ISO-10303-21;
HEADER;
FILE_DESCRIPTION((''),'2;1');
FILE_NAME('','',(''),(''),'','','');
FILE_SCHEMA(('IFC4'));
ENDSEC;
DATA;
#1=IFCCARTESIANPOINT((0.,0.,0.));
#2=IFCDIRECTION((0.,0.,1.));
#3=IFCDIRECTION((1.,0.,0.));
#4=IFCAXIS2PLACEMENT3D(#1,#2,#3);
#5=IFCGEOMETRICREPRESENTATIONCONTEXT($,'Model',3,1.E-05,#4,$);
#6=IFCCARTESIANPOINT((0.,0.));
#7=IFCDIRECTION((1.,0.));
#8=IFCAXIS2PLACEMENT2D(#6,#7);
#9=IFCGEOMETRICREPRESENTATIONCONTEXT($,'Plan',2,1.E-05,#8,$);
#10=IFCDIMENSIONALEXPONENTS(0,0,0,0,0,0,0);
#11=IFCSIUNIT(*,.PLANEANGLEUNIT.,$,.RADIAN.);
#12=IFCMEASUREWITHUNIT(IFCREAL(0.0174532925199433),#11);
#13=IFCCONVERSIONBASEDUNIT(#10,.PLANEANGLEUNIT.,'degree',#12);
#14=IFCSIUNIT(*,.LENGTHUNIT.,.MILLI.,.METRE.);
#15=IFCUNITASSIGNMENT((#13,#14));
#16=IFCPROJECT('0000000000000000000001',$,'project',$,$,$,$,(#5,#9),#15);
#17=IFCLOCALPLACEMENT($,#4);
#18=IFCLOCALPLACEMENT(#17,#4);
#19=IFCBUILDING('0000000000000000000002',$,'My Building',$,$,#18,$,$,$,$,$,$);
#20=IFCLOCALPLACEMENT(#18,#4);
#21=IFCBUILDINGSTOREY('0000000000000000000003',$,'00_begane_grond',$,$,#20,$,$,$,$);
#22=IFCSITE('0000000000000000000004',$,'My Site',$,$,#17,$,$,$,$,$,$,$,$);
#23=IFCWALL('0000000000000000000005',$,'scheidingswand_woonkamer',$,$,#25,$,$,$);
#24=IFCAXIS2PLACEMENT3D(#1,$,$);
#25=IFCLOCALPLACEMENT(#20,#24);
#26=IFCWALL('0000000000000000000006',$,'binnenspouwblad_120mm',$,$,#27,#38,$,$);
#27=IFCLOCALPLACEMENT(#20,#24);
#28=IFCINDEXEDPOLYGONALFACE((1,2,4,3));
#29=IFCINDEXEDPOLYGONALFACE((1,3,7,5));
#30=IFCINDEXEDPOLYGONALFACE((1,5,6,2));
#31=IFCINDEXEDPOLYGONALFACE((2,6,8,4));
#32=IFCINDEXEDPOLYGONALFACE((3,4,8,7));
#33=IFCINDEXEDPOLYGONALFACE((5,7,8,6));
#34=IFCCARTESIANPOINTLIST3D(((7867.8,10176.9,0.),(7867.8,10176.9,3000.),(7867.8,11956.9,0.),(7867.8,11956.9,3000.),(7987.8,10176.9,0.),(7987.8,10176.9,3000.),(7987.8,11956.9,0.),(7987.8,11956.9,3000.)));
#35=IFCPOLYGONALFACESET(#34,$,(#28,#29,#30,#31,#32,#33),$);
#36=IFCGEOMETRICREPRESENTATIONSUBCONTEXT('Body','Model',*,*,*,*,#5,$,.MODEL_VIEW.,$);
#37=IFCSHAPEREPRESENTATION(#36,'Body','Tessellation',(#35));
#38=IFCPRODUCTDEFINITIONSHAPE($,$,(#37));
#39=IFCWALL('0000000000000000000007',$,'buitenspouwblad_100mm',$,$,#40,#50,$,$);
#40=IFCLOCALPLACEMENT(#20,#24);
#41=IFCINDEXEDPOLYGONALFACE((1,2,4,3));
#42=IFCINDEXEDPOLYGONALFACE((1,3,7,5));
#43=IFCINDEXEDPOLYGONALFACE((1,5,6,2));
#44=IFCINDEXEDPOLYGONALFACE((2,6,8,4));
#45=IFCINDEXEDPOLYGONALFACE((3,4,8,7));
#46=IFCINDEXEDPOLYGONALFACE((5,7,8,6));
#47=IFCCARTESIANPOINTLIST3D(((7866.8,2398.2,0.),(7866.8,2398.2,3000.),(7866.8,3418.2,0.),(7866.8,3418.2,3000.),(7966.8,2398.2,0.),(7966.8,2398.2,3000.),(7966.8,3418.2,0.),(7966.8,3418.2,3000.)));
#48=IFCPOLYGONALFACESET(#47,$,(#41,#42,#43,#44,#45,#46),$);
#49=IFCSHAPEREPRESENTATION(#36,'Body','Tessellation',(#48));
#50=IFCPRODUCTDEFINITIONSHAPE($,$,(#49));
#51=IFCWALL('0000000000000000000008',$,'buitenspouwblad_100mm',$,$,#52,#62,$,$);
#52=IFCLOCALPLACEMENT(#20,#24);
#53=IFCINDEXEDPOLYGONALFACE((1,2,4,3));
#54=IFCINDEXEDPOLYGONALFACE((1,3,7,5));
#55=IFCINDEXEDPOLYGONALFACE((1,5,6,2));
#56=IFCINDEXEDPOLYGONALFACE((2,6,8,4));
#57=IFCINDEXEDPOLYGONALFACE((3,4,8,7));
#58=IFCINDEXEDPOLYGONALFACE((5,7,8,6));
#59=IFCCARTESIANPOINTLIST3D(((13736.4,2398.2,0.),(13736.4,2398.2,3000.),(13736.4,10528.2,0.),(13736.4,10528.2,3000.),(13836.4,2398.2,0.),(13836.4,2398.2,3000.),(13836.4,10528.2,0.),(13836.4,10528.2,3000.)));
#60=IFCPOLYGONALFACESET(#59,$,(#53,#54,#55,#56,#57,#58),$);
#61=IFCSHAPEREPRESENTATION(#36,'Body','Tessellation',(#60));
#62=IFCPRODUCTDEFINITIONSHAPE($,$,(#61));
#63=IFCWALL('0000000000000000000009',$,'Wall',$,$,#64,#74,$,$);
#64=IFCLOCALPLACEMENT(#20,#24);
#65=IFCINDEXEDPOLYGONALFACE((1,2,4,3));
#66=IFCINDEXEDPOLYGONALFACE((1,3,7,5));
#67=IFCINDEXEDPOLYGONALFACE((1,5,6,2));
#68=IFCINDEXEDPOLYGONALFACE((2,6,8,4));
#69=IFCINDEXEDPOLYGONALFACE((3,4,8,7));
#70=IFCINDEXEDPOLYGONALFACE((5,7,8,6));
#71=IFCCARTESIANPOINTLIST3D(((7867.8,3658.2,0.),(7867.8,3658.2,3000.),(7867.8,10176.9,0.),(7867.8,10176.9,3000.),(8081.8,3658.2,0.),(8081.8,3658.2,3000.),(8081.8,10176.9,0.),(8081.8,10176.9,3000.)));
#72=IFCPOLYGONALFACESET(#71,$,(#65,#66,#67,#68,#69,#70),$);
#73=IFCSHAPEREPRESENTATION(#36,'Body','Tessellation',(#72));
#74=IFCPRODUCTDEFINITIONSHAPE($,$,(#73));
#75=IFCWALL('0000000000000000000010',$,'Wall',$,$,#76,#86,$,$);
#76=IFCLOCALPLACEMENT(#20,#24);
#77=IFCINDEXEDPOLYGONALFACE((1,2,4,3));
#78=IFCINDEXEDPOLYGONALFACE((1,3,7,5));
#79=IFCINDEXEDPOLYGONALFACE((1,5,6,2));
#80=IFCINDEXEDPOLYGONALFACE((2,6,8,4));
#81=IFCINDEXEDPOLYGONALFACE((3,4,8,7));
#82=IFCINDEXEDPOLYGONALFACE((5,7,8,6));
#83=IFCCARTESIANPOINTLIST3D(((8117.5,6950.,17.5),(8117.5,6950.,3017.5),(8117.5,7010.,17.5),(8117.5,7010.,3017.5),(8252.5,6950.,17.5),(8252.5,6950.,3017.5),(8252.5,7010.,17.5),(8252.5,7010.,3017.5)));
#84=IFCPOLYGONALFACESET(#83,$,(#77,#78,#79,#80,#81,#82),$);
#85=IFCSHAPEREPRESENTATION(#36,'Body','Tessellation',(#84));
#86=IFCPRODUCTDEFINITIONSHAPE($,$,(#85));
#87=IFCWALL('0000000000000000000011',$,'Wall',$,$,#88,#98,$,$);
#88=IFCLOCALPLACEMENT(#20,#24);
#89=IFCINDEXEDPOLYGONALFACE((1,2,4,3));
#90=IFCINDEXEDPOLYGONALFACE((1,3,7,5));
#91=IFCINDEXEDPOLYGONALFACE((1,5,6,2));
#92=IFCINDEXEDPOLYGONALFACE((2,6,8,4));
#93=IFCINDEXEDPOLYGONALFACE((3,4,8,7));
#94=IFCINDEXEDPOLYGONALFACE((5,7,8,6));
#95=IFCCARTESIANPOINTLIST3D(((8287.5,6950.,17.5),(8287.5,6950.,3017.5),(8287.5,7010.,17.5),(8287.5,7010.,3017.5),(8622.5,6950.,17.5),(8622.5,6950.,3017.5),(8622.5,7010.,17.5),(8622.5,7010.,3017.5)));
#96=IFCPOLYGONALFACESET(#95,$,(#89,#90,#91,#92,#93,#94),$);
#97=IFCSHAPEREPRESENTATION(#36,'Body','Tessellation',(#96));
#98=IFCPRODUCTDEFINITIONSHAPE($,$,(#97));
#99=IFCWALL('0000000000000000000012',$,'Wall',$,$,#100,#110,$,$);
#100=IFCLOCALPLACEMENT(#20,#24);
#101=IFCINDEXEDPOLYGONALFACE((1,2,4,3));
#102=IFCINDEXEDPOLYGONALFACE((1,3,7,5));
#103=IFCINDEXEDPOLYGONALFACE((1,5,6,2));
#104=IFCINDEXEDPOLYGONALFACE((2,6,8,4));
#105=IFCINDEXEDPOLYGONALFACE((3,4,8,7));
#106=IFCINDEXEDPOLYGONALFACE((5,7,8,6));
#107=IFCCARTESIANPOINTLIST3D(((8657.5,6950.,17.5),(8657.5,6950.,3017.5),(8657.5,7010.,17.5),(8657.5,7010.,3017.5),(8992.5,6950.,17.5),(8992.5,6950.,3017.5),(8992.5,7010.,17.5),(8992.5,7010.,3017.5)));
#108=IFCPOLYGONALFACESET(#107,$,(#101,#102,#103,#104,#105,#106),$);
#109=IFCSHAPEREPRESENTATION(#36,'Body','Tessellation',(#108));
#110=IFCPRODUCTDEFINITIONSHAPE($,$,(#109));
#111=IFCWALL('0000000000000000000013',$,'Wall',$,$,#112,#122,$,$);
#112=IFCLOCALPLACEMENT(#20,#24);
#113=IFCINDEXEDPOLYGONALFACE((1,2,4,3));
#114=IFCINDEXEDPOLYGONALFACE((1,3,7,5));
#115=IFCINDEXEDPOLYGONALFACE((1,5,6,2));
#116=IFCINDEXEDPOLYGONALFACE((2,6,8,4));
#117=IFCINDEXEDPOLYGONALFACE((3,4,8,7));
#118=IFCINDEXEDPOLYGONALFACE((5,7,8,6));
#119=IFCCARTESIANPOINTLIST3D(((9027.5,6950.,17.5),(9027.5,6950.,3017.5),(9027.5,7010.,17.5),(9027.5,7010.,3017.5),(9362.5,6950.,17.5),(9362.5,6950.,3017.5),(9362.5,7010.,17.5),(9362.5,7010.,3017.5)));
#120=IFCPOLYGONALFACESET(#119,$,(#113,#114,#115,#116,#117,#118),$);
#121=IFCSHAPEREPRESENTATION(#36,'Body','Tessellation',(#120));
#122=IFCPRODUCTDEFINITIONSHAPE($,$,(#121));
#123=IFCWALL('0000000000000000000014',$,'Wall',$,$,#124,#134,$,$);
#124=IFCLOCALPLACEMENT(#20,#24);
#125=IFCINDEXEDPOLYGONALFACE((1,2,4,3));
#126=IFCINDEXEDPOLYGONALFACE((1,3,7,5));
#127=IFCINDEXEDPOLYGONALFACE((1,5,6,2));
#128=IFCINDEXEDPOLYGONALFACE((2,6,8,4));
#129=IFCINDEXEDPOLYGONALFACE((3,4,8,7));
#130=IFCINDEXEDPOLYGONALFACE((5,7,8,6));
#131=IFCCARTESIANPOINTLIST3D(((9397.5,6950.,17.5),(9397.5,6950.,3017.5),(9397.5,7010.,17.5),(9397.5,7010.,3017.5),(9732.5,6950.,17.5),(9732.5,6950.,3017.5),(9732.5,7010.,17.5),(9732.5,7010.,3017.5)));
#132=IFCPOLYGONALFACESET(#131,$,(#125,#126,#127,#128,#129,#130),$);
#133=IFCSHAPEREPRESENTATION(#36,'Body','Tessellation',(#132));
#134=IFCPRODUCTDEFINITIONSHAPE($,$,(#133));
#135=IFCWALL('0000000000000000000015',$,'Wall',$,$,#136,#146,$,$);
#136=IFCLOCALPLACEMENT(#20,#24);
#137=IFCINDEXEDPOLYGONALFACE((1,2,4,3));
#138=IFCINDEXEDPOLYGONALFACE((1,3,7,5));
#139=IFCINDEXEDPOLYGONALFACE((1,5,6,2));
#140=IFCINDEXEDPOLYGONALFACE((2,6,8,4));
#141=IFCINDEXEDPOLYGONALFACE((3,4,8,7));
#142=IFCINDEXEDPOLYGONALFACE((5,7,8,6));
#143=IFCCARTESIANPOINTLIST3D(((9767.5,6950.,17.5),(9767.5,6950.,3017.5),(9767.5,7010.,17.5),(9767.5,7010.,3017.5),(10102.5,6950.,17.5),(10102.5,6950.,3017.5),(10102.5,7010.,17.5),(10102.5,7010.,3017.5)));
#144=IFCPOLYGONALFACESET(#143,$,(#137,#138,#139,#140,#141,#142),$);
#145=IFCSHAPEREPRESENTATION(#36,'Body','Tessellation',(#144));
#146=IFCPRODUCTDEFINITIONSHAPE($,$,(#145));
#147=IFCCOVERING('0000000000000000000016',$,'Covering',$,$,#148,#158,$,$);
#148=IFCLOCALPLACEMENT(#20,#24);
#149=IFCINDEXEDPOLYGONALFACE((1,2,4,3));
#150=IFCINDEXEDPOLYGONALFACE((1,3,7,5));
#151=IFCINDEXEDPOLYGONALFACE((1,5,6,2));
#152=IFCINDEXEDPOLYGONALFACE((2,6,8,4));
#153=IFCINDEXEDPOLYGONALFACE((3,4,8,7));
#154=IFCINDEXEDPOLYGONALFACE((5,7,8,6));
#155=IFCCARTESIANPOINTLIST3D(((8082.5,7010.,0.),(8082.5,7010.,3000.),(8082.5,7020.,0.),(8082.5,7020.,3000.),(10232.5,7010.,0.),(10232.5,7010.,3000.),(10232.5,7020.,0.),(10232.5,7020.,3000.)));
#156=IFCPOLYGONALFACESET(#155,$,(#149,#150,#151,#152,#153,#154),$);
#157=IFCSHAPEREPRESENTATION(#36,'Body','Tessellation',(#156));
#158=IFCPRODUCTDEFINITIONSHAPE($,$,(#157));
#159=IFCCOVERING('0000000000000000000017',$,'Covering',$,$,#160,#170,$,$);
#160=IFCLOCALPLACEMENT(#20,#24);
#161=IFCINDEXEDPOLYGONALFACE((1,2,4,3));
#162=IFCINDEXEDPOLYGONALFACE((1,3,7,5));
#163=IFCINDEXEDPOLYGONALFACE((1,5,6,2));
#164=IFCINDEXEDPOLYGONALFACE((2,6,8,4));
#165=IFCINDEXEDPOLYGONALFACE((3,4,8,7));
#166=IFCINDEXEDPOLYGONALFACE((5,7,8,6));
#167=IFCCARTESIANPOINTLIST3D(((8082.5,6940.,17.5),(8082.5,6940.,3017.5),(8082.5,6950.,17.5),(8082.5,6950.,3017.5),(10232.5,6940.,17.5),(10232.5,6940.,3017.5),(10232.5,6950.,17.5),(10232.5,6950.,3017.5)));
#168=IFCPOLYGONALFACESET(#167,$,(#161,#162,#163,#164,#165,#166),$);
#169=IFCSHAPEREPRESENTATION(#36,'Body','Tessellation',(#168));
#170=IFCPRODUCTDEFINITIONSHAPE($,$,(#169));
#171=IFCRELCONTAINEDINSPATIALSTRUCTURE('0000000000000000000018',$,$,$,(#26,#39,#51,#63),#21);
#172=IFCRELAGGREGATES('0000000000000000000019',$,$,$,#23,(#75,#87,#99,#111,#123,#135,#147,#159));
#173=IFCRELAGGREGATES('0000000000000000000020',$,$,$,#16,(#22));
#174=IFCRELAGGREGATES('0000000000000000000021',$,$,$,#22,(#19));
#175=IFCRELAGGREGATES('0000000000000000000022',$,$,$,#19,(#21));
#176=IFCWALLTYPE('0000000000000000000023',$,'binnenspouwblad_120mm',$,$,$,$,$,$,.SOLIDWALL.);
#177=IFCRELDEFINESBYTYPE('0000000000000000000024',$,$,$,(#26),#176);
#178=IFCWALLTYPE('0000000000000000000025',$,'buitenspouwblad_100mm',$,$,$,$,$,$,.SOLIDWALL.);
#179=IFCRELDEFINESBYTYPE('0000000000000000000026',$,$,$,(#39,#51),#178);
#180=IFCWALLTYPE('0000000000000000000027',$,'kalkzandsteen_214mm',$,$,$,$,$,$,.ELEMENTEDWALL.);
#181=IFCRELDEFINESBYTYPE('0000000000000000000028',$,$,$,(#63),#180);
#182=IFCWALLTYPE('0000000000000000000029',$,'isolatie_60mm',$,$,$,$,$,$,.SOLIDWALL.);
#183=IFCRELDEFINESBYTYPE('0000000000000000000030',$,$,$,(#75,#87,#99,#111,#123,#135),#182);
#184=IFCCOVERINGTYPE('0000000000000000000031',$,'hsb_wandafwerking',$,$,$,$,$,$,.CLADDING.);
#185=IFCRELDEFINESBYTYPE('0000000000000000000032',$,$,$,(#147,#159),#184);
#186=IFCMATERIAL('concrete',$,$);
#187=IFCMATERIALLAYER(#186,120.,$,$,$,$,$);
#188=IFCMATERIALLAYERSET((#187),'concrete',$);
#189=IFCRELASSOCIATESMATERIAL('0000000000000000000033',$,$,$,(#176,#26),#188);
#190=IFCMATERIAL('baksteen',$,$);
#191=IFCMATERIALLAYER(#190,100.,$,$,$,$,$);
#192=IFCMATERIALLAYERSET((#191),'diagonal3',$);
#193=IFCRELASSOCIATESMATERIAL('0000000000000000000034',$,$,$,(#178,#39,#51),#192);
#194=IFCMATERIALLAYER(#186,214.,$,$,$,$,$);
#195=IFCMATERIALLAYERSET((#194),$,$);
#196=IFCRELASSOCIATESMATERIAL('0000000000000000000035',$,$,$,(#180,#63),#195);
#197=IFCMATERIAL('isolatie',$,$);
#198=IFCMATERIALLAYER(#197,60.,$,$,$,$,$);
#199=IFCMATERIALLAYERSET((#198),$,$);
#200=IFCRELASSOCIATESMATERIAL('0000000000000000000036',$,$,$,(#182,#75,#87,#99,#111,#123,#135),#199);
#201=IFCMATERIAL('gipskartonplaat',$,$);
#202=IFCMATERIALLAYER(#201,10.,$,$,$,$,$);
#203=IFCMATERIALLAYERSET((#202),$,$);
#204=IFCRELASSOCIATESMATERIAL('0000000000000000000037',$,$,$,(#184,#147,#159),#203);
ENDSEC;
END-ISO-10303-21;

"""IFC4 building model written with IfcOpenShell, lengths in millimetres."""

from ifc_helpers import new_model, entity, si_unit, converted_unit, frame, origin_with_axes, origin_2d_with_axis, place, context, subcontext, project, spatial, indexed_curve, outline, extrude, material, layer, layer_set, layer_usage, type_object, element, aggregate, save


model = new_model("IFC4")

# Units and contexts
model_context = context("Model", 3, precision=1e-05, world=origin_with_axes())
plan_context = context("Plan", 2, precision=1e-05, world=origin_2d_with_axis())
body_context = subcontext(model_context, "Body", "Model", "MODEL_VIEW")
ifc_project = project(units=[converted_unit("PLANEANGLEUNIT", "degree", entity("IfcReal", 0.0174532925199433), si_unit("PLANEANGLEUNIT", "RADIAN"), dimensions=[0, 0, 0, 0, 0, 0, 0]), si_unit("LENGTHUNIT", "METRE", prefix="MILLI")], contexts=[model_context, plan_context])

# Site, building, storey
site_placement = place(None, origin_with_axes())
site = spatial("IfcSite", under=ifc_project, at=site_placement, Name="My Site")
building_placement = place(site_placement, origin_with_axes())
building = spatial("IfcBuilding", under=site, at=building_placement, Name="My Building")
storey_placement = place(building_placement, origin_with_axes())
storey = spatial("IfcBuildingStorey", under=building, at=storey_placement, Name="00_begane_grond")

# Wall
wall_1_placement = place(storey_placement, origin_with_axes())
wall_2_placement = place(wall_1_placement, origin_with_axes())
wall_2 = element("IfcWall", 1, at=wall_2_placement, Name="scheidingswand_woonkamer")

# Walls
ifc_material_1 = material(Name="isolatie")
ifc_material_2 = material(Name="concrete")
ifc_layer_1 = layer(ifc_material_2, 120.0)
ifc_layer_set_1 = layer_set([ifc_layer_1], Name="concrete")
wall_type_1 = type_object("IfcWallType", Name="binnenspouwblad_120mm", PredefinedType="SOLIDWALL", material=ifc_layer_set_1)
ifc_layer_usage_1 = layer_usage(ifc_layer_set_1, "AXIS2", "POSITIVE", 0.0)
wall_3_placement = place(storey_placement, frame((7987.8, 10176.9, 0.0), z_axis=(0.0, 0.0, 1.0), x_axis=(0.000002, 1.0, 0.0)))
element("IfcWall", 2, at=wall_3_placement, inside=storey, type_object=wall_type_1, material=ifc_layer_usage_1, Name="binnenspouwblad_120mm", context=body_context, shape_type="SweptSolid", body=[
    extrude(outline(indexed_curve([(0.0, 0.0), (0.0, 120.0), (1780.0, 120.0), (1780.0, 0.0), (0.0, 0.0)], self_intersect=False)), origin_with_axes(), (0.0, 0.0, 1.0), 3000.0),
])
ifc_material_3 = material(Name="baksteen")
ifc_layer_2 = layer(ifc_material_3, 100.0)
ifc_layer_set_2 = layer_set([ifc_layer_2], Name="diagonal3")
ifc_layer_usage_2 = layer_usage(ifc_layer_set_2, "AXIS2", "POSITIVE", 0.0)
wall_type_2 = type_object("IfcWallType", Name="buitenspouwblad_100mm", PredefinedType="SOLIDWALL", material=ifc_layer_set_2)
wall_4_placement = place(storey_placement, frame((7966.8, 2398.2, 0.0), z_axis=(0.0, 0.0, 1.0), x_axis=(0.000001, 1.0, 0.0)))
element("IfcWall", 3, at=wall_4_placement, inside=storey, type_object=wall_type_2, material=ifc_layer_usage_2, Name="buitenspouwblad_100mm", context=body_context, shape_type="SweptSolid", body=[
    extrude(outline(indexed_curve([(0.0, 0.0), (0.0, 100.0), (1020.0, 100.0), (1020.0, 0.0), (0.0, 0.0)], self_intersect=False)), origin_with_axes(), (0.0, 0.0, 1.0), 3000.0),
])
ifc_layer_usage_3 = layer_usage(ifc_layer_set_2, "AXIS2", "POSITIVE", 0.0)
wall_5_placement = place(storey_placement, frame((13836.4, 2398.2, 0.0), z_axis=(0.0, 0.0, 1.0), x_axis=(0.0, 1.0, 0.0)))
element("IfcWall", 4, at=wall_5_placement, inside=storey, type_object=wall_type_2, material=ifc_layer_usage_3, Name="buitenspouwblad_100mm", context=body_context, shape_type="SweptSolid", body=[
    extrude(outline(indexed_curve([(0.0, 0.0), (0.0, 100.0), (8130.0, 100.0), (8130.0, 0.0), (0.0, 0.0)], self_intersect=False)), origin_with_axes(), (0.0, 0.0, 1.0), 3000.0),
])
ifc_layer_3 = layer(ifc_material_2, 214.0)
ifc_layer_set_3 = layer_set([ifc_layer_3])
ifc_layer_usage_4 = layer_usage(ifc_layer_set_3, "AXIS2", "POSITIVE", 0.0)
wall_type_3 = type_object("IfcWallType", Name="kalkzandsteen_214mm", PredefinedType="ELEMENTEDWALL", material=ifc_layer_set_3)
wall_6_placement = place(storey_placement, frame((7867.8, 10176.9, 0.0), z_axis=(0.0, 0.0, 1.0), x_axis=(-0.000001, -1.0, 0.0)))
element("IfcWall", 5, at=wall_6_placement, inside=storey, type_object=wall_type_3, material=ifc_layer_usage_4, Name="Wall", context=body_context, shape_type="SweptSolid", body=[
    extrude(outline(indexed_curve([(0.0, 0.0), (0.0, 214.0), (6518.8, 214.0), (6518.8, 0.0), (0.0, 0.0)], self_intersect=False)), origin_with_axes(), (0.0, 0.0, 1.0), 3000.0),
])

# Walls
ifc_layer_4 = layer(ifc_material_1, 60.0)
ifc_layer_set_4 = layer_set([ifc_layer_4])
ifc_layer_usage_5 = layer_usage(ifc_layer_set_4, "AXIS2", "POSITIVE", 0.0)
wall_type_4 = type_object("IfcWallType", Name="isolatie_60mm", PredefinedType="SOLIDWALL", material=ifc_layer_set_4)
wall_7_placement = place(wall_2_placement, frame((8117.5, 6950.0, 17.5), z_axis=(0.0, 0.0, 1.0), x_axis=(1.0, 0.0, 0.0)))
wall_7 = element("IfcWall", 6, at=wall_7_placement, type_object=wall_type_4, material=ifc_layer_usage_5, Name="Wall", context=body_context, shape_type="SweptSolid", body=[
    extrude(outline(indexed_curve([(0.0, 0.0), (0.0, 60.0), (135.0, 60.0), (135.0, 0.0), (0.0, 0.0)], self_intersect=False)), origin_with_axes(), (0.0, 0.0, 1.0), 3000.0),
])
ifc_layer_usage_6 = layer_usage(ifc_layer_set_4, "AXIS2", "POSITIVE", 0.0)
wall_8_placement = place(wall_2_placement, frame((8287.5, 6950.0, 17.5), z_axis=(0.0, 0.0, 1.0), x_axis=(1.0, 0.0, 0.0)))
wall_8 = element("IfcWall", 7, at=wall_8_placement, type_object=wall_type_4, material=ifc_layer_usage_6, Name="Wall", context=body_context, shape_type="SweptSolid", body=[
    extrude(outline(indexed_curve([(0.0, 0.0), (0.0, 60.0), (335.0, 60.0), (335.0, 0.0), (0.0, 0.0)], self_intersect=False)), origin_with_axes(), (0.0, 0.0, 1.0), 3000.0),
])
ifc_layer_usage_7 = layer_usage(ifc_layer_set_4, "AXIS2", "POSITIVE", 0.0)
wall_9_placement = place(wall_2_placement, frame((8657.5, 6950.0, 17.5), z_axis=(0.0, 0.0, 1.0), x_axis=(1.0, 0.0, 0.0)))
wall_9 = element("IfcWall", 8, at=wall_9_placement, type_object=wall_type_4, material=ifc_layer_usage_7, Name="Wall", context=body_context, shape_type="SweptSolid", body=[
    extrude(outline(indexed_curve([(0.0, 0.0), (0.0, 60.0), (335.0, 60.0), (335.0, 0.0), (0.0, 0.0)], self_intersect=False)), origin_with_axes(), (0.0, 0.0, 1.0), 3000.0),
])
ifc_layer_usage_8 = layer_usage(ifc_layer_set_4, "AXIS2", "POSITIVE", 0.0)
wall_10_placement = place(wall_2_placement, frame((9027.5, 6950.0, 17.5), z_axis=(0.0, 0.0, 1.0), x_axis=(1.0, 0.0, 0.0)))
wall_10 = element("IfcWall", 9, at=wall_10_placement, type_object=wall_type_4, material=ifc_layer_usage_8, Name="Wall", context=body_context, shape_type="SweptSolid", body=[
    extrude(outline(indexed_curve([(0.0, 0.0), (0.0, 60.0), (335.0, 60.0), (335.0, 0.0), (0.0, 0.0)], self_intersect=False)), origin_with_axes(), (0.0, 0.0, 1.0), 3000.0),
])
ifc_layer_usage_9 = layer_usage(ifc_layer_set_4, "AXIS2", "POSITIVE", 0.0)
wall_11_placement = place(wall_2_placement, frame((9397.5, 6950.0, 17.5), z_axis=(0.0, 0.0, 1.0), x_axis=(1.0, 0.0, 0.0)))
wall_11 = element("IfcWall", 10, at=wall_11_placement, type_object=wall_type_4, material=ifc_layer_usage_9, Name="Wall", context=body_context, shape_type="SweptSolid", body=[
    extrude(outline(indexed_curve([(0.0, 0.0), (0.0, 60.0), (335.0, 60.0), (335.0, 0.0), (0.0, 0.0)], self_intersect=False)), origin_with_axes(), (0.0, 0.0, 1.0), 3000.0),
])
ifc_layer_usage_10 = layer_usage(ifc_layer_set_4, "AXIS2", "POSITIVE", 0.0)
wall_12_placement = place(wall_2_placement, frame((9767.5, 6950.0, 17.5), z_axis=(0.0, 0.0, 1.0), x_axis=(1.0, 0.0, 0.0)))
wall_12 = element("IfcWall", 11, at=wall_12_placement, type_object=wall_type_4, material=ifc_layer_usage_10, Name="Wall", context=body_context, shape_type="SweptSolid", body=[
    extrude(outline(indexed_curve([(0.0, 0.0), (0.0, 60.0), (335.0, 60.0), (335.0, 0.0), (0.0, 0.0)], self_intersect=False)), origin_with_axes(), (0.0, 0.0, 1.0), 3000.0),
])

# Coverings
ifc_material_4 = material(Name="gipskartonplaat")
ifc_layer_5 = layer(ifc_material_4, 10.0)
ifc_layer_set_5 = layer_set([ifc_layer_5])
ifc_layer_usage_11 = layer_usage(ifc_layer_set_5, "AXIS2", "POSITIVE", 0.0)
covering_type = type_object("IfcCoveringType", Name="hsb_wandafwerking", PredefinedType="CLADDING", material=ifc_layer_set_5)
covering_1_placement = place(wall_2_placement, frame((8082.5, 7010.0, 0.0), z_axis=(0.0, 0.0, 1.0), x_axis=(1.0, 0.0, 0.0)))
covering_1 = element("IfcCovering", 12, at=covering_1_placement, type_object=covering_type, material=ifc_layer_usage_11, Name="Covering", context=body_context, shape_type="SweptSolid", body=[
    extrude(outline(indexed_curve([(0.0, 0.0), (0.0, 10.0), (2150.0, 10.0), (2150.0, 0.0), (0.0, 0.0)], self_intersect=False)), origin_with_axes(), (0.0, 0.0, 1.0), 3000.0),
])
ifc_layer_usage_12 = layer_usage(ifc_layer_set_5, "AXIS2", "POSITIVE", 0.0)
covering_2_placement = place(wall_2_placement, frame((10232.5, 6950.0, 17.5), z_axis=(0.0, 0.0, 1.0), x_axis=(-1.0, 0.0, 0.0)))
covering_2 = element("IfcCovering", 13, at=covering_2_placement, type_object=covering_type, material=ifc_layer_usage_12, Name="Covering", context=body_context, shape_type="SweptSolid", body=[
    extrude(outline(indexed_curve([(0.0, 0.0), (0.0, 10.0), (2150.0, 10.0), (2150.0, 0.0), (0.0, 0.0)], self_intersect=False)), origin_with_axes(), (0.0, 0.0, 1.0), 3000.0),
])
aggregate(wall_2, [wall_7, wall_8, wall_9, wall_10, wall_11, wall_12, covering_1, covering_2])

save(model, "model.ifc")
